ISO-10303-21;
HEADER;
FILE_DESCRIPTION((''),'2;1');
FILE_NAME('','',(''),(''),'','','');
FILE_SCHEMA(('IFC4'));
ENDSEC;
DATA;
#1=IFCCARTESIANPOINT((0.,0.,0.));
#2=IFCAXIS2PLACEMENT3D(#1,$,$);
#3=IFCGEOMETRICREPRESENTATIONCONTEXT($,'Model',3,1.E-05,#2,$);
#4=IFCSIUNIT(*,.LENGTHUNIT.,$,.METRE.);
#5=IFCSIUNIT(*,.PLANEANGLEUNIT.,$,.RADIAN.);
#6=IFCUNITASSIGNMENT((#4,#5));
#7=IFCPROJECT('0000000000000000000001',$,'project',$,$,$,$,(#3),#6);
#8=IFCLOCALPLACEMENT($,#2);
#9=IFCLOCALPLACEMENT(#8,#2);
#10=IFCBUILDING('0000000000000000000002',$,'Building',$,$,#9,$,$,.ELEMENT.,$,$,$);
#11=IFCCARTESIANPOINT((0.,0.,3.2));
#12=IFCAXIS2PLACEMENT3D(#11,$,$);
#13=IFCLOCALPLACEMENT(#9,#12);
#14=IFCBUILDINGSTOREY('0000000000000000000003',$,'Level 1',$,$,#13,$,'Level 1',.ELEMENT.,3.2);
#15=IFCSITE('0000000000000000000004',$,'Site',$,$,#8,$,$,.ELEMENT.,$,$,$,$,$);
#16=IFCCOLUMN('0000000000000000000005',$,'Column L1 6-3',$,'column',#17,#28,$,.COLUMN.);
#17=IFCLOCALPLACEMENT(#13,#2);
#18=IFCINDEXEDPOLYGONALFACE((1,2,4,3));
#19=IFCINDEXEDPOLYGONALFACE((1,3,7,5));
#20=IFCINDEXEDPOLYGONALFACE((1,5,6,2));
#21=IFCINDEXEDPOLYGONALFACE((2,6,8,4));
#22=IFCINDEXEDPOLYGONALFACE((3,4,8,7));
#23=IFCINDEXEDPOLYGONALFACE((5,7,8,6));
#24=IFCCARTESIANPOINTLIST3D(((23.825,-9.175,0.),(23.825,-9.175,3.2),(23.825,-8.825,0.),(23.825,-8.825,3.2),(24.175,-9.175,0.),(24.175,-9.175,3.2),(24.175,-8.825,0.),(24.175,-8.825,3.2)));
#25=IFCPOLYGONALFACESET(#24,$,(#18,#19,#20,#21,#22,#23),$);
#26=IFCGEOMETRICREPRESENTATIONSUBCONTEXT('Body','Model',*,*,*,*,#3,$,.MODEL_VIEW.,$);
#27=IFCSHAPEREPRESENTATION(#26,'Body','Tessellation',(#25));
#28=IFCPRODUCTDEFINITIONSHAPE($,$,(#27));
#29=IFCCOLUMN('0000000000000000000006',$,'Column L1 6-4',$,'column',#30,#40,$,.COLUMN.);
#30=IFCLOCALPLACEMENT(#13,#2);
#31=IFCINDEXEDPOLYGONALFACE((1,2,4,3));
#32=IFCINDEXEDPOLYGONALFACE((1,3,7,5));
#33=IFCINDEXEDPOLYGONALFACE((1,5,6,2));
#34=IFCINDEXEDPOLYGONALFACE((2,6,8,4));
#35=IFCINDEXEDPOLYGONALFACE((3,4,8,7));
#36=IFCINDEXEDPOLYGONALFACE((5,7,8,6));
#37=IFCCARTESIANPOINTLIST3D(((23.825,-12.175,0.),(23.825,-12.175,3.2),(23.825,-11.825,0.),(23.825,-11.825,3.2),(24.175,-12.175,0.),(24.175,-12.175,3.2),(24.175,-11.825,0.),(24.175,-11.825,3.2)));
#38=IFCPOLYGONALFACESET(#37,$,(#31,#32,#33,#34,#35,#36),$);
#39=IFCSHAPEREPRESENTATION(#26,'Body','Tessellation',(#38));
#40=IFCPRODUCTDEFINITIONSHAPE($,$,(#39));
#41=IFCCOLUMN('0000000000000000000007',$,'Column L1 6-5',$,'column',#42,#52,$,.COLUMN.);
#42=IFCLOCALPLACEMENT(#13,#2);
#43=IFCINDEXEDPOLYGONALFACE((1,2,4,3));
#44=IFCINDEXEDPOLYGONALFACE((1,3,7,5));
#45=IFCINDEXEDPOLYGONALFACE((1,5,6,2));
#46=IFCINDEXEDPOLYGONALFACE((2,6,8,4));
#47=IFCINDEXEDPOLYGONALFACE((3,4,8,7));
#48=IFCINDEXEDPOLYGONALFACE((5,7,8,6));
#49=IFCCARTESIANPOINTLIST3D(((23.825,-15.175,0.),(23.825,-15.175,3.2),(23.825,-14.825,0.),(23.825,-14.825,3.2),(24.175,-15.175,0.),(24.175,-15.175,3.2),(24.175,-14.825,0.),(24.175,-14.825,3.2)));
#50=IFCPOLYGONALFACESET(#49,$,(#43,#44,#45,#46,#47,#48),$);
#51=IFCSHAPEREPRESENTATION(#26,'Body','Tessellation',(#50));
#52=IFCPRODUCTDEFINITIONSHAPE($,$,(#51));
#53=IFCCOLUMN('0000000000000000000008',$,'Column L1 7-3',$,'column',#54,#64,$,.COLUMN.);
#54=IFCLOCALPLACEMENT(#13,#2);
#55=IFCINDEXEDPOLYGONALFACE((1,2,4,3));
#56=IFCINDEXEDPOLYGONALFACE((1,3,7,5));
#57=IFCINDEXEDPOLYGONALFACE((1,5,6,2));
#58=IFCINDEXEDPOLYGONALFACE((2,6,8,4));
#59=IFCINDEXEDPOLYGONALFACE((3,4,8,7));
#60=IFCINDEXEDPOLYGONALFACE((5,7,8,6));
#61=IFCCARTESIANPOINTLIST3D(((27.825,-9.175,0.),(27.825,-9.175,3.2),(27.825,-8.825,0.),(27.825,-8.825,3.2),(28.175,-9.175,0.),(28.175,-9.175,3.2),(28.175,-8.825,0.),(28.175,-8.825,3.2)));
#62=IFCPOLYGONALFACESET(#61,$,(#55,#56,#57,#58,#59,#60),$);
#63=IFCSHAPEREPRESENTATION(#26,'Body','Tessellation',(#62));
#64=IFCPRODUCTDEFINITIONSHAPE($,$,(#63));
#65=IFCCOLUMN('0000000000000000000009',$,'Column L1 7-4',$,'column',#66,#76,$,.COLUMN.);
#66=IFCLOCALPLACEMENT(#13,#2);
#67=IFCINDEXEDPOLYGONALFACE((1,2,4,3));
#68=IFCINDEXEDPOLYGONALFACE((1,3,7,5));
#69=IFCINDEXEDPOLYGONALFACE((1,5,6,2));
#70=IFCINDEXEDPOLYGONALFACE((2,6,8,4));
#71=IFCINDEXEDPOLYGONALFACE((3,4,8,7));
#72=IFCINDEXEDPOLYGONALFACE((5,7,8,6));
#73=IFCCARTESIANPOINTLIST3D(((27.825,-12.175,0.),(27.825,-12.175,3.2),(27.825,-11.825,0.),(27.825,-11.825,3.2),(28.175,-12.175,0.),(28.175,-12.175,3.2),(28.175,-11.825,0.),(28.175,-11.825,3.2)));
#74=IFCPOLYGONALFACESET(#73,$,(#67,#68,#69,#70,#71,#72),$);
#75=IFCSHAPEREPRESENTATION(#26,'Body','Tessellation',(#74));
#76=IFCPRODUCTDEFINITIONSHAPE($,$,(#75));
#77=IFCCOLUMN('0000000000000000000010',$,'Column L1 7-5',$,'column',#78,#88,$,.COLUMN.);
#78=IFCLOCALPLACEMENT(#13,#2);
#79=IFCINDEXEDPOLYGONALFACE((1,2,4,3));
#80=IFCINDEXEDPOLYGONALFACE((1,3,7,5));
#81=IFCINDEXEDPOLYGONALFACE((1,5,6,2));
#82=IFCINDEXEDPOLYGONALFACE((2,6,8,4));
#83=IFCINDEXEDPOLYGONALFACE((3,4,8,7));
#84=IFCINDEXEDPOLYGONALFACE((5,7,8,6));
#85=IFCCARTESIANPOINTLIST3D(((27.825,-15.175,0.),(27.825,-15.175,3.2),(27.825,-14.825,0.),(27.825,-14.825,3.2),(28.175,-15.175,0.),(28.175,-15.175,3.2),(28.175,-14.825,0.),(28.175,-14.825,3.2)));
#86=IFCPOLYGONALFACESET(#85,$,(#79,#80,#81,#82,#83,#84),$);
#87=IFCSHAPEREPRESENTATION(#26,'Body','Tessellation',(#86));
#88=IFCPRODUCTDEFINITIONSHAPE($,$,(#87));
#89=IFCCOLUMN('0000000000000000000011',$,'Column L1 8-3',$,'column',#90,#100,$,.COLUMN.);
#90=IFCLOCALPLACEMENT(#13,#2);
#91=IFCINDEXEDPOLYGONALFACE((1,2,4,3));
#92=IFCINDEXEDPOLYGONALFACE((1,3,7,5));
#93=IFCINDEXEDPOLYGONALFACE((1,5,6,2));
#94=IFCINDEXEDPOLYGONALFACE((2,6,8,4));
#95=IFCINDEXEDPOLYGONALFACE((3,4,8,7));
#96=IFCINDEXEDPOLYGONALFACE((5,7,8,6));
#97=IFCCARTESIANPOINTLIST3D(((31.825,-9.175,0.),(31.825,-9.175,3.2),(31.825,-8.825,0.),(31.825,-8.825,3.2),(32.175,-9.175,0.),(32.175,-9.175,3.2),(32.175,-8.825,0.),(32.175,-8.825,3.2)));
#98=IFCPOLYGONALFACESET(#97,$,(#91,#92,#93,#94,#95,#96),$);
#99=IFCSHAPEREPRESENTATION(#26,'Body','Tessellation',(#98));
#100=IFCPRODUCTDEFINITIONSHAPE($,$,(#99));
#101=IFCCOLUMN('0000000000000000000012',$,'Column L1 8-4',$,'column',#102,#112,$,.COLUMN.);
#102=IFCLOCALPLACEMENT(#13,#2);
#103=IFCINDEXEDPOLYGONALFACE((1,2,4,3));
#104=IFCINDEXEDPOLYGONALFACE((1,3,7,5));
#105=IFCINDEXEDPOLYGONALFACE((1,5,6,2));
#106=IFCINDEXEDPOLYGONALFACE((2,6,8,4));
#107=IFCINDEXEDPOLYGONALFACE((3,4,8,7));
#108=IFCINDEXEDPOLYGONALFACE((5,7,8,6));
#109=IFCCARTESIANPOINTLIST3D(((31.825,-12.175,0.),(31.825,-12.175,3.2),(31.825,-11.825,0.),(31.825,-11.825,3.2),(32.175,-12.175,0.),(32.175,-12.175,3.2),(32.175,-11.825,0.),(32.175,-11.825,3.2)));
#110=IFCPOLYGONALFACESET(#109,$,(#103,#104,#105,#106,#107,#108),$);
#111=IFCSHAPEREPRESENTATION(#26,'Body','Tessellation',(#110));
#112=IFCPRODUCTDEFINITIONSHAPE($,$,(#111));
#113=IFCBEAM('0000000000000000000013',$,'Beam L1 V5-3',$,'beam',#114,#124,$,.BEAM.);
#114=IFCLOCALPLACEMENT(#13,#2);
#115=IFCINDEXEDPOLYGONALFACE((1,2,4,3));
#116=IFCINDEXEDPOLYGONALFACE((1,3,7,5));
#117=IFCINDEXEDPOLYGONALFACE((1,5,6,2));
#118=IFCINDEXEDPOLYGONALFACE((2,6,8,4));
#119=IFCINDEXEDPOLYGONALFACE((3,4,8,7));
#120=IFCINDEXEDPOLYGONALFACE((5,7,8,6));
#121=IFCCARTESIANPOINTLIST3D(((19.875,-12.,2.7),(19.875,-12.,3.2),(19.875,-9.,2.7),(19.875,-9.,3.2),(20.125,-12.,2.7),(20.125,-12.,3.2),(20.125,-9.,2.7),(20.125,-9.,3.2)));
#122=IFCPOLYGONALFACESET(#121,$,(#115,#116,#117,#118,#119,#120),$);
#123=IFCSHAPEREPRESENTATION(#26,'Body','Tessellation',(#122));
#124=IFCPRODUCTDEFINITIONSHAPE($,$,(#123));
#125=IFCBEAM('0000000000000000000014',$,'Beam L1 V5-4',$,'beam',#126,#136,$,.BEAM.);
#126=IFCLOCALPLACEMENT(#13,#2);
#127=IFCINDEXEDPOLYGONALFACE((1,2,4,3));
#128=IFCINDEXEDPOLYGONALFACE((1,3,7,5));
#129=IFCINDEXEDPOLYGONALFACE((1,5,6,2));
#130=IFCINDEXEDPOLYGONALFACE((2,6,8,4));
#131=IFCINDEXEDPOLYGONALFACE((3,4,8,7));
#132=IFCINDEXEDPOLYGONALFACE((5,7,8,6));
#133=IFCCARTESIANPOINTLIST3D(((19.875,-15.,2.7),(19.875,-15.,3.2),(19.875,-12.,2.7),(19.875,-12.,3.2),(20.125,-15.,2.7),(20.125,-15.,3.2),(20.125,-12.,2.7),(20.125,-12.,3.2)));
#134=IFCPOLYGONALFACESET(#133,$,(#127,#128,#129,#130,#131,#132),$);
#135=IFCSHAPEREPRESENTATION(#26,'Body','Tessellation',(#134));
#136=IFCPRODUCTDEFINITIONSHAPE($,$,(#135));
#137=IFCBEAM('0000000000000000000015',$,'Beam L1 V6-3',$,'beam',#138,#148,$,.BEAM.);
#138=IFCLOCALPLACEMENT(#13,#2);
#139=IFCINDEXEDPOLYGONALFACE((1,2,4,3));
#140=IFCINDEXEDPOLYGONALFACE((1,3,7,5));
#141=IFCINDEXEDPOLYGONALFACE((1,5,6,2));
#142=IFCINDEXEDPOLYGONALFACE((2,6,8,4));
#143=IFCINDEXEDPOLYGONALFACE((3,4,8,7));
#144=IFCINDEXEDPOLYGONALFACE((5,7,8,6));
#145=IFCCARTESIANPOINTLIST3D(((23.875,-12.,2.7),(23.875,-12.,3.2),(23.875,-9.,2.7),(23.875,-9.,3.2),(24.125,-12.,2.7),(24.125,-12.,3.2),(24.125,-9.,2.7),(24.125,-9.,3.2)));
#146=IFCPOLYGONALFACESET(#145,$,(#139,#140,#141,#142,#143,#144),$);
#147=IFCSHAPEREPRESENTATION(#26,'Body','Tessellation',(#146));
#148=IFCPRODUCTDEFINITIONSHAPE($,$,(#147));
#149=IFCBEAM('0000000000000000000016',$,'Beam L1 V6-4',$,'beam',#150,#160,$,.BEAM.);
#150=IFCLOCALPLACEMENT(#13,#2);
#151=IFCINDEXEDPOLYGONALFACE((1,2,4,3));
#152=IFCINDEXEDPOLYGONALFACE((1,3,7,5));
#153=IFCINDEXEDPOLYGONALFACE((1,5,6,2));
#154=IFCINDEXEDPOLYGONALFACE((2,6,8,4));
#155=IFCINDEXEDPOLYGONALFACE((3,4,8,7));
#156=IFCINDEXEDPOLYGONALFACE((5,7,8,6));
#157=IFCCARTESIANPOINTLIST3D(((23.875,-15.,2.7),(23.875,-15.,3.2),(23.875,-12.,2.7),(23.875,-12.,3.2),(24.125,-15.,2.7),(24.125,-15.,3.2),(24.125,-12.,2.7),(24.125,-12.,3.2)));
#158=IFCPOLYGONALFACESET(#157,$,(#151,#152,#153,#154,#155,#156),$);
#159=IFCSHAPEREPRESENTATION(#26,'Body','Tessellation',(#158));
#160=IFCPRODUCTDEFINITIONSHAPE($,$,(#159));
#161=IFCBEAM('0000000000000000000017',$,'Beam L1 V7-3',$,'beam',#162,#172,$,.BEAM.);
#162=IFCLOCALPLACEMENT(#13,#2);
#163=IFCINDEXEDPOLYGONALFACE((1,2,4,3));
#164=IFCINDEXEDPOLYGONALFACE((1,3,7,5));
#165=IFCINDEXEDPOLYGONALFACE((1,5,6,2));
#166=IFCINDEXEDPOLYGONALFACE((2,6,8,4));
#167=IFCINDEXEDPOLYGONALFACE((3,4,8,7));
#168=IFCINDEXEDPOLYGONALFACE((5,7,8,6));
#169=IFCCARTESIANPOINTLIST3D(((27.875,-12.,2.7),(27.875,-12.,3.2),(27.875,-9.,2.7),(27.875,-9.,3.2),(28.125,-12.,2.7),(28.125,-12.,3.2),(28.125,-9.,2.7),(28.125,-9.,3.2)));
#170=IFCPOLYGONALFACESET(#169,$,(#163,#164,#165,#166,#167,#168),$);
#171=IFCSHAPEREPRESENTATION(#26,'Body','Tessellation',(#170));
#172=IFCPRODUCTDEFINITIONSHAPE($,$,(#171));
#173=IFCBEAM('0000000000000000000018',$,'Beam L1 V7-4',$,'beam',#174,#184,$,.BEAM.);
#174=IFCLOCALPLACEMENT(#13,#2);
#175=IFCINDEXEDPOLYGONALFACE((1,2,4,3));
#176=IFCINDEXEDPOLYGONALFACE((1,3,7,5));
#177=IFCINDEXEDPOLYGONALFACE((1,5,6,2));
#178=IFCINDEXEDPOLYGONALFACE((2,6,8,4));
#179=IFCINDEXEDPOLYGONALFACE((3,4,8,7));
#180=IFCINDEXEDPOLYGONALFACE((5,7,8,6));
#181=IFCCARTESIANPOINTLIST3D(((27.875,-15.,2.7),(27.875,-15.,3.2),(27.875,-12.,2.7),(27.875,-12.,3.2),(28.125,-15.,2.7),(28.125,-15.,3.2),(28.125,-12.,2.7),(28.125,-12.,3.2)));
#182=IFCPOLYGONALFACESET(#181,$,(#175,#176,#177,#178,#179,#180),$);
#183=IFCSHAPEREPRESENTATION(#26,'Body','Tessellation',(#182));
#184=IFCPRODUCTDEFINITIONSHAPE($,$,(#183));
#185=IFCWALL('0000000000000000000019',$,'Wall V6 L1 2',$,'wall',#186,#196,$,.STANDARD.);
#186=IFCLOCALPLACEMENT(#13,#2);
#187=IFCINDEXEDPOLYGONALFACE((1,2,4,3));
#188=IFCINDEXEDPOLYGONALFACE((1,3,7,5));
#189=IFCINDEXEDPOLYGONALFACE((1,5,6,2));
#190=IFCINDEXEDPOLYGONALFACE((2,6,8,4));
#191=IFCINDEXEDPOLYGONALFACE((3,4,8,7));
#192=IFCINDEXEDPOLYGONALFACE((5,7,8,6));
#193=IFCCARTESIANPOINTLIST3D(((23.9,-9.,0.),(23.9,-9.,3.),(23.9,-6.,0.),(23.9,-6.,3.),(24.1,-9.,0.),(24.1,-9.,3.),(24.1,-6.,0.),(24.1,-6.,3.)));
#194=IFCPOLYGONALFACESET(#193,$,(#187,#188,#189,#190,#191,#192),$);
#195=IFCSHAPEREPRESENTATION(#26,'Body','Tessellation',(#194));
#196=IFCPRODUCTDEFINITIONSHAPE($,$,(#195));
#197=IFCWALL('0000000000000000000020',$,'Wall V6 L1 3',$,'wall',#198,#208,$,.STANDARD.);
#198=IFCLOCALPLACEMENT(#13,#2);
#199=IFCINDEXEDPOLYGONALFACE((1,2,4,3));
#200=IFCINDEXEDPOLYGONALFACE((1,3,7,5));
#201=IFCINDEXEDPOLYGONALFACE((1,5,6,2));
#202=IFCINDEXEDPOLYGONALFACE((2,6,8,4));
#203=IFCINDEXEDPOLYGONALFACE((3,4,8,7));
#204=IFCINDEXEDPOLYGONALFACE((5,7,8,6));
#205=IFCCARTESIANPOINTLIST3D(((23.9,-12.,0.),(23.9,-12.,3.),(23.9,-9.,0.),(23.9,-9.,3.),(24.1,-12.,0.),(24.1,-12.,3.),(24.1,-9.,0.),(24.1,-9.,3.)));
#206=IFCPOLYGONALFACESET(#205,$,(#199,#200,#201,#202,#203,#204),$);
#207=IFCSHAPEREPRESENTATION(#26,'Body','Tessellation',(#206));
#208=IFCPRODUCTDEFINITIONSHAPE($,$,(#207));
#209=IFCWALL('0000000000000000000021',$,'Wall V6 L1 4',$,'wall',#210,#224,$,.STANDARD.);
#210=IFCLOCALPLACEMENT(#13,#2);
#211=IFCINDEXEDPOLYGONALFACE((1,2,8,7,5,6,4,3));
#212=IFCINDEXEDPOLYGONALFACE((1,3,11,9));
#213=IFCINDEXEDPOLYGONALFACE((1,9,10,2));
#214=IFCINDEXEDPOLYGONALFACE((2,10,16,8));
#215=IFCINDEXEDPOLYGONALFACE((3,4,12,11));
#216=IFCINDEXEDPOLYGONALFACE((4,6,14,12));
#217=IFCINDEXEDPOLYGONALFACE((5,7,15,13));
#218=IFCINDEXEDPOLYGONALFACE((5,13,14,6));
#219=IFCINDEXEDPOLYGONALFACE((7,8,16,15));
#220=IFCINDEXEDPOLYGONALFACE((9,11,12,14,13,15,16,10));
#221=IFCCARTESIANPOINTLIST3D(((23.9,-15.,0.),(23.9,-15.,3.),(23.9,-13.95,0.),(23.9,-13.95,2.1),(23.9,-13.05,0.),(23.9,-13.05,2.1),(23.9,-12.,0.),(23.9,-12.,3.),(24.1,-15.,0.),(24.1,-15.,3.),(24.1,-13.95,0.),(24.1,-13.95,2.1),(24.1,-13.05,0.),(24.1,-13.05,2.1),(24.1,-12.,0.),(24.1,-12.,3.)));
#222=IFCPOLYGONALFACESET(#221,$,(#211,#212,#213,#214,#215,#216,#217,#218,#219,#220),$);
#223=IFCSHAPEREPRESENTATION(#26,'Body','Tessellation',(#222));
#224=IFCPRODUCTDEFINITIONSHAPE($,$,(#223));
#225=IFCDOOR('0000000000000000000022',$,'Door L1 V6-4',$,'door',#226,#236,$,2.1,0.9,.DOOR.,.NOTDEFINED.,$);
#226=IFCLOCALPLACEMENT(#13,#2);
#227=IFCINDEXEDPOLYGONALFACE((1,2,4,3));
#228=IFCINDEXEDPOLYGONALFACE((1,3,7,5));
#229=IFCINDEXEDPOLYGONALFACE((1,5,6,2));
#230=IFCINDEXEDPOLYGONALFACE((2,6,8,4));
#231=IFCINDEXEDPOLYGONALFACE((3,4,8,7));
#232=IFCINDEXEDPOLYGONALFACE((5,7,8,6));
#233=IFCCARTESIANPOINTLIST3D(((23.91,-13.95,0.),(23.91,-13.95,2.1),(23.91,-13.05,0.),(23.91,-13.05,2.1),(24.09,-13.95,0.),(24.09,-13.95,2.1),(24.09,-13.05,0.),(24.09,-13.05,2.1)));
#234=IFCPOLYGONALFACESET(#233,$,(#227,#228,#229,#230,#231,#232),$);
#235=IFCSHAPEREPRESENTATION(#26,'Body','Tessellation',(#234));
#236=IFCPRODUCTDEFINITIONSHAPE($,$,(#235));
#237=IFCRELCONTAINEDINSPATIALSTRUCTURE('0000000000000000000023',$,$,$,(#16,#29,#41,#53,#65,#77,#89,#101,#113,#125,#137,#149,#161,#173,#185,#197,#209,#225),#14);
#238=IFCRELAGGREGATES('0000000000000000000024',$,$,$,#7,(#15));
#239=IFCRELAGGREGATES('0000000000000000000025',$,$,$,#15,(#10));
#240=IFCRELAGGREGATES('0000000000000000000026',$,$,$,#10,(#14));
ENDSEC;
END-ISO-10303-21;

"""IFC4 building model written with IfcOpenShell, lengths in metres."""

from ifc_helpers import new_model, si_unit, frame, frame_2d, origin, origin_2d, place, context, subcontext, project, spatial, rectangle, extrude, element, fill, save


model = new_model("IFC4")

# Units and contexts
model_context = context("Model", 3, precision=1e-05, world=origin())
body_context = subcontext(model_context, "Body", "Model", "MODEL_VIEW")
ifc_project = project(units=[si_unit("LENGTHUNIT", "METRE"), si_unit("PLANEANGLEUNIT", "RADIAN")], contexts=[model_context])

# Site, building, storey
site_placement = place(None, origin())
site = spatial("IfcSite", under=ifc_project, at=site_placement, Name="Site", CompositionType="ELEMENT")
building_placement = place(site_placement, origin())
building = spatial("IfcBuilding", under=site, at=building_placement, Name="Building", CompositionType="ELEMENT")
storey_placement = place(building_placement, frame((0.0, 0.0, 3.2)))
storey = spatial("IfcBuildingStorey", under=building, at=storey_placement, Name="Level 1", LongName="Level 1", CompositionType="ELEMENT", Elevation=3.2)

# Columns
for number, where, name in (
    (1, (24.0, -9.0, 0.0), "Column L1 6-3"),
    (2, (24.0, -12.0, 0.0), "Column L1 6-4"),
    (3, (24.0, -15.0, 0.0), "Column L1 6-5"),
    (4, (28.0, -9.0, 0.0), "Column L1 7-3"),
    (5, (28.0, -12.0, 0.0), "Column L1 7-4"),
    (6, (28.0, -15.0, 0.0), "Column L1 7-5"),
    (7, (32.0, -9.0, 0.0), "Column L1 8-3"),
    (8, (32.0, -12.0, 0.0), "Column L1 8-4"),
):
    element("IfcColumn", number, at=place(storey_placement, frame(where)), inside=storey, Name=name, ObjectType="column", PredefinedType="COLUMN", context=body_context, shape_type="SweptSolid", body=[
        extrude(rectangle(XDim=0.35, YDim=0.35, at=origin_2d()), origin(), (0.0, 0.0, 1.0), 3.2),
    ])

# Beams
for number, where, z_axis, x_axis, name in (
    (9, (20.0, -9.0, 2.95), (0.0, -1.0, 0.0), (0.0, 0.0, 1.0), "Beam L1 V5-3"),
    (10, (20.0, -12.0, 2.95), (0.0, -1.0, 0.0), (0.0, 0.0, 1.0), "Beam L1 V5-4"),
    (11, (24.0, -9.0, 2.95), (0.0, -1.0, 0.0), (0.0, 0.0, 1.0), "Beam L1 V6-3"),
    (12, (24.0, -12.0, 2.95), (0.0, -1.0, 0.0), (0.0, 0.0, 1.0), "Beam L1 V6-4"),
    (13, (28.0, -9.0, 2.95), (0.0, -1.0, 0.0), (0.0, 0.0, 1.0), "Beam L1 V7-3"),
    (14, (28.0, -12.0, 2.95), (0.0, -1.0, 0.0), (0.0, 0.0, 1.0), "Beam L1 V7-4"),
):
    element("IfcBeam", number, at=place(storey_placement, frame(where, z_axis=z_axis, x_axis=x_axis)), inside=storey, Name=name, ObjectType="beam", PredefinedType="BEAM", context=body_context, shape_type="SweptSolid", body=[
        extrude(rectangle(XDim=0.5, YDim=0.25, at=origin_2d()), origin(), (0.0, 0.0, 1.0), 3.0),
    ])

# Walls
for number, where, z_axis, x_axis, name in (
    (15, (24.0, -6.0, 0.0), (0.0, 0.0, 1.0), (0.0, -1.0, 0.0), "Wall V6 L1 2"),
    (16, (24.0, -9.0, 0.0), (0.0, 0.0, 1.0), (0.0, -1.0, 0.0), "Wall V6 L1 3"),
):
    element("IfcWall", number, at=place(storey_placement, frame(where, z_axis=z_axis, x_axis=x_axis)), inside=storey, Name=name, ObjectType="wall", PredefinedType="STANDARD", context=body_context, shape_type="SweptSolid", body=[
        extrude(rectangle(XDim=3.0, YDim=0.2, at=frame_2d((1.5, 0.0))), origin(), (0.0, 0.0, 1.0), 3.0),
    ])

# Wall, opening, door
wall_1_placement = place(storey_placement, frame((24.0, -12.0, 0.0), z_axis=(0.0, 0.0, 1.0), x_axis=(0.0, -1.0, 0.0)))
wall_1 = element("IfcWall", 17, at=wall_1_placement, inside=storey, Name="Wall V6 L1 4", ObjectType="wall", PredefinedType="STANDARD", context=body_context, shape_type="SweptSolid", body=[
    extrude(rectangle(XDim=3.0, YDim=0.2, at=frame_2d((1.5, 0.0))), origin(), (0.0, 0.0, 1.0), 3.0),
])
opening_1_placement = place(storey_placement, frame((24.0, -13.5, 0.0), z_axis=(0.0, 0.0, 1.0), x_axis=(0.0, -1.0, 0.0)))
opening_1 = element("IfcOpeningElement", 18, at=opening_1_placement, cuts=wall_1, ObjectType="Opening", PredefinedType="OPENING", context=body_context, shape_type="SweptSolid", body=[
    extrude(rectangle(XDim=0.9, YDim=0.22, at=origin_2d()), origin(), (0.0, 0.0, 1.0), 2.1),
])
door_1_placement = place(storey_placement, frame((24.0, -13.5, 0.0), z_axis=(0.0, 0.0, 1.0), x_axis=(0.0, -1.0, 0.0)))
door_1 = element("IfcDoor", 19, at=door_1_placement, inside=storey, Name="Door L1 V6-4", ObjectType="door", OperationType="NOTDEFINED", OverallHeight=2.1, OverallWidth=0.9, PredefinedType="DOOR", context=body_context, shape_type="SweptSolid", body=[
    extrude(rectangle(XDim=0.9, YDim=0.18, at=origin_2d()), origin(), (0.0, 0.0, 1.0), 2.1),
])
fill(opening_1, door_1)

save(model, "model.ifc")
